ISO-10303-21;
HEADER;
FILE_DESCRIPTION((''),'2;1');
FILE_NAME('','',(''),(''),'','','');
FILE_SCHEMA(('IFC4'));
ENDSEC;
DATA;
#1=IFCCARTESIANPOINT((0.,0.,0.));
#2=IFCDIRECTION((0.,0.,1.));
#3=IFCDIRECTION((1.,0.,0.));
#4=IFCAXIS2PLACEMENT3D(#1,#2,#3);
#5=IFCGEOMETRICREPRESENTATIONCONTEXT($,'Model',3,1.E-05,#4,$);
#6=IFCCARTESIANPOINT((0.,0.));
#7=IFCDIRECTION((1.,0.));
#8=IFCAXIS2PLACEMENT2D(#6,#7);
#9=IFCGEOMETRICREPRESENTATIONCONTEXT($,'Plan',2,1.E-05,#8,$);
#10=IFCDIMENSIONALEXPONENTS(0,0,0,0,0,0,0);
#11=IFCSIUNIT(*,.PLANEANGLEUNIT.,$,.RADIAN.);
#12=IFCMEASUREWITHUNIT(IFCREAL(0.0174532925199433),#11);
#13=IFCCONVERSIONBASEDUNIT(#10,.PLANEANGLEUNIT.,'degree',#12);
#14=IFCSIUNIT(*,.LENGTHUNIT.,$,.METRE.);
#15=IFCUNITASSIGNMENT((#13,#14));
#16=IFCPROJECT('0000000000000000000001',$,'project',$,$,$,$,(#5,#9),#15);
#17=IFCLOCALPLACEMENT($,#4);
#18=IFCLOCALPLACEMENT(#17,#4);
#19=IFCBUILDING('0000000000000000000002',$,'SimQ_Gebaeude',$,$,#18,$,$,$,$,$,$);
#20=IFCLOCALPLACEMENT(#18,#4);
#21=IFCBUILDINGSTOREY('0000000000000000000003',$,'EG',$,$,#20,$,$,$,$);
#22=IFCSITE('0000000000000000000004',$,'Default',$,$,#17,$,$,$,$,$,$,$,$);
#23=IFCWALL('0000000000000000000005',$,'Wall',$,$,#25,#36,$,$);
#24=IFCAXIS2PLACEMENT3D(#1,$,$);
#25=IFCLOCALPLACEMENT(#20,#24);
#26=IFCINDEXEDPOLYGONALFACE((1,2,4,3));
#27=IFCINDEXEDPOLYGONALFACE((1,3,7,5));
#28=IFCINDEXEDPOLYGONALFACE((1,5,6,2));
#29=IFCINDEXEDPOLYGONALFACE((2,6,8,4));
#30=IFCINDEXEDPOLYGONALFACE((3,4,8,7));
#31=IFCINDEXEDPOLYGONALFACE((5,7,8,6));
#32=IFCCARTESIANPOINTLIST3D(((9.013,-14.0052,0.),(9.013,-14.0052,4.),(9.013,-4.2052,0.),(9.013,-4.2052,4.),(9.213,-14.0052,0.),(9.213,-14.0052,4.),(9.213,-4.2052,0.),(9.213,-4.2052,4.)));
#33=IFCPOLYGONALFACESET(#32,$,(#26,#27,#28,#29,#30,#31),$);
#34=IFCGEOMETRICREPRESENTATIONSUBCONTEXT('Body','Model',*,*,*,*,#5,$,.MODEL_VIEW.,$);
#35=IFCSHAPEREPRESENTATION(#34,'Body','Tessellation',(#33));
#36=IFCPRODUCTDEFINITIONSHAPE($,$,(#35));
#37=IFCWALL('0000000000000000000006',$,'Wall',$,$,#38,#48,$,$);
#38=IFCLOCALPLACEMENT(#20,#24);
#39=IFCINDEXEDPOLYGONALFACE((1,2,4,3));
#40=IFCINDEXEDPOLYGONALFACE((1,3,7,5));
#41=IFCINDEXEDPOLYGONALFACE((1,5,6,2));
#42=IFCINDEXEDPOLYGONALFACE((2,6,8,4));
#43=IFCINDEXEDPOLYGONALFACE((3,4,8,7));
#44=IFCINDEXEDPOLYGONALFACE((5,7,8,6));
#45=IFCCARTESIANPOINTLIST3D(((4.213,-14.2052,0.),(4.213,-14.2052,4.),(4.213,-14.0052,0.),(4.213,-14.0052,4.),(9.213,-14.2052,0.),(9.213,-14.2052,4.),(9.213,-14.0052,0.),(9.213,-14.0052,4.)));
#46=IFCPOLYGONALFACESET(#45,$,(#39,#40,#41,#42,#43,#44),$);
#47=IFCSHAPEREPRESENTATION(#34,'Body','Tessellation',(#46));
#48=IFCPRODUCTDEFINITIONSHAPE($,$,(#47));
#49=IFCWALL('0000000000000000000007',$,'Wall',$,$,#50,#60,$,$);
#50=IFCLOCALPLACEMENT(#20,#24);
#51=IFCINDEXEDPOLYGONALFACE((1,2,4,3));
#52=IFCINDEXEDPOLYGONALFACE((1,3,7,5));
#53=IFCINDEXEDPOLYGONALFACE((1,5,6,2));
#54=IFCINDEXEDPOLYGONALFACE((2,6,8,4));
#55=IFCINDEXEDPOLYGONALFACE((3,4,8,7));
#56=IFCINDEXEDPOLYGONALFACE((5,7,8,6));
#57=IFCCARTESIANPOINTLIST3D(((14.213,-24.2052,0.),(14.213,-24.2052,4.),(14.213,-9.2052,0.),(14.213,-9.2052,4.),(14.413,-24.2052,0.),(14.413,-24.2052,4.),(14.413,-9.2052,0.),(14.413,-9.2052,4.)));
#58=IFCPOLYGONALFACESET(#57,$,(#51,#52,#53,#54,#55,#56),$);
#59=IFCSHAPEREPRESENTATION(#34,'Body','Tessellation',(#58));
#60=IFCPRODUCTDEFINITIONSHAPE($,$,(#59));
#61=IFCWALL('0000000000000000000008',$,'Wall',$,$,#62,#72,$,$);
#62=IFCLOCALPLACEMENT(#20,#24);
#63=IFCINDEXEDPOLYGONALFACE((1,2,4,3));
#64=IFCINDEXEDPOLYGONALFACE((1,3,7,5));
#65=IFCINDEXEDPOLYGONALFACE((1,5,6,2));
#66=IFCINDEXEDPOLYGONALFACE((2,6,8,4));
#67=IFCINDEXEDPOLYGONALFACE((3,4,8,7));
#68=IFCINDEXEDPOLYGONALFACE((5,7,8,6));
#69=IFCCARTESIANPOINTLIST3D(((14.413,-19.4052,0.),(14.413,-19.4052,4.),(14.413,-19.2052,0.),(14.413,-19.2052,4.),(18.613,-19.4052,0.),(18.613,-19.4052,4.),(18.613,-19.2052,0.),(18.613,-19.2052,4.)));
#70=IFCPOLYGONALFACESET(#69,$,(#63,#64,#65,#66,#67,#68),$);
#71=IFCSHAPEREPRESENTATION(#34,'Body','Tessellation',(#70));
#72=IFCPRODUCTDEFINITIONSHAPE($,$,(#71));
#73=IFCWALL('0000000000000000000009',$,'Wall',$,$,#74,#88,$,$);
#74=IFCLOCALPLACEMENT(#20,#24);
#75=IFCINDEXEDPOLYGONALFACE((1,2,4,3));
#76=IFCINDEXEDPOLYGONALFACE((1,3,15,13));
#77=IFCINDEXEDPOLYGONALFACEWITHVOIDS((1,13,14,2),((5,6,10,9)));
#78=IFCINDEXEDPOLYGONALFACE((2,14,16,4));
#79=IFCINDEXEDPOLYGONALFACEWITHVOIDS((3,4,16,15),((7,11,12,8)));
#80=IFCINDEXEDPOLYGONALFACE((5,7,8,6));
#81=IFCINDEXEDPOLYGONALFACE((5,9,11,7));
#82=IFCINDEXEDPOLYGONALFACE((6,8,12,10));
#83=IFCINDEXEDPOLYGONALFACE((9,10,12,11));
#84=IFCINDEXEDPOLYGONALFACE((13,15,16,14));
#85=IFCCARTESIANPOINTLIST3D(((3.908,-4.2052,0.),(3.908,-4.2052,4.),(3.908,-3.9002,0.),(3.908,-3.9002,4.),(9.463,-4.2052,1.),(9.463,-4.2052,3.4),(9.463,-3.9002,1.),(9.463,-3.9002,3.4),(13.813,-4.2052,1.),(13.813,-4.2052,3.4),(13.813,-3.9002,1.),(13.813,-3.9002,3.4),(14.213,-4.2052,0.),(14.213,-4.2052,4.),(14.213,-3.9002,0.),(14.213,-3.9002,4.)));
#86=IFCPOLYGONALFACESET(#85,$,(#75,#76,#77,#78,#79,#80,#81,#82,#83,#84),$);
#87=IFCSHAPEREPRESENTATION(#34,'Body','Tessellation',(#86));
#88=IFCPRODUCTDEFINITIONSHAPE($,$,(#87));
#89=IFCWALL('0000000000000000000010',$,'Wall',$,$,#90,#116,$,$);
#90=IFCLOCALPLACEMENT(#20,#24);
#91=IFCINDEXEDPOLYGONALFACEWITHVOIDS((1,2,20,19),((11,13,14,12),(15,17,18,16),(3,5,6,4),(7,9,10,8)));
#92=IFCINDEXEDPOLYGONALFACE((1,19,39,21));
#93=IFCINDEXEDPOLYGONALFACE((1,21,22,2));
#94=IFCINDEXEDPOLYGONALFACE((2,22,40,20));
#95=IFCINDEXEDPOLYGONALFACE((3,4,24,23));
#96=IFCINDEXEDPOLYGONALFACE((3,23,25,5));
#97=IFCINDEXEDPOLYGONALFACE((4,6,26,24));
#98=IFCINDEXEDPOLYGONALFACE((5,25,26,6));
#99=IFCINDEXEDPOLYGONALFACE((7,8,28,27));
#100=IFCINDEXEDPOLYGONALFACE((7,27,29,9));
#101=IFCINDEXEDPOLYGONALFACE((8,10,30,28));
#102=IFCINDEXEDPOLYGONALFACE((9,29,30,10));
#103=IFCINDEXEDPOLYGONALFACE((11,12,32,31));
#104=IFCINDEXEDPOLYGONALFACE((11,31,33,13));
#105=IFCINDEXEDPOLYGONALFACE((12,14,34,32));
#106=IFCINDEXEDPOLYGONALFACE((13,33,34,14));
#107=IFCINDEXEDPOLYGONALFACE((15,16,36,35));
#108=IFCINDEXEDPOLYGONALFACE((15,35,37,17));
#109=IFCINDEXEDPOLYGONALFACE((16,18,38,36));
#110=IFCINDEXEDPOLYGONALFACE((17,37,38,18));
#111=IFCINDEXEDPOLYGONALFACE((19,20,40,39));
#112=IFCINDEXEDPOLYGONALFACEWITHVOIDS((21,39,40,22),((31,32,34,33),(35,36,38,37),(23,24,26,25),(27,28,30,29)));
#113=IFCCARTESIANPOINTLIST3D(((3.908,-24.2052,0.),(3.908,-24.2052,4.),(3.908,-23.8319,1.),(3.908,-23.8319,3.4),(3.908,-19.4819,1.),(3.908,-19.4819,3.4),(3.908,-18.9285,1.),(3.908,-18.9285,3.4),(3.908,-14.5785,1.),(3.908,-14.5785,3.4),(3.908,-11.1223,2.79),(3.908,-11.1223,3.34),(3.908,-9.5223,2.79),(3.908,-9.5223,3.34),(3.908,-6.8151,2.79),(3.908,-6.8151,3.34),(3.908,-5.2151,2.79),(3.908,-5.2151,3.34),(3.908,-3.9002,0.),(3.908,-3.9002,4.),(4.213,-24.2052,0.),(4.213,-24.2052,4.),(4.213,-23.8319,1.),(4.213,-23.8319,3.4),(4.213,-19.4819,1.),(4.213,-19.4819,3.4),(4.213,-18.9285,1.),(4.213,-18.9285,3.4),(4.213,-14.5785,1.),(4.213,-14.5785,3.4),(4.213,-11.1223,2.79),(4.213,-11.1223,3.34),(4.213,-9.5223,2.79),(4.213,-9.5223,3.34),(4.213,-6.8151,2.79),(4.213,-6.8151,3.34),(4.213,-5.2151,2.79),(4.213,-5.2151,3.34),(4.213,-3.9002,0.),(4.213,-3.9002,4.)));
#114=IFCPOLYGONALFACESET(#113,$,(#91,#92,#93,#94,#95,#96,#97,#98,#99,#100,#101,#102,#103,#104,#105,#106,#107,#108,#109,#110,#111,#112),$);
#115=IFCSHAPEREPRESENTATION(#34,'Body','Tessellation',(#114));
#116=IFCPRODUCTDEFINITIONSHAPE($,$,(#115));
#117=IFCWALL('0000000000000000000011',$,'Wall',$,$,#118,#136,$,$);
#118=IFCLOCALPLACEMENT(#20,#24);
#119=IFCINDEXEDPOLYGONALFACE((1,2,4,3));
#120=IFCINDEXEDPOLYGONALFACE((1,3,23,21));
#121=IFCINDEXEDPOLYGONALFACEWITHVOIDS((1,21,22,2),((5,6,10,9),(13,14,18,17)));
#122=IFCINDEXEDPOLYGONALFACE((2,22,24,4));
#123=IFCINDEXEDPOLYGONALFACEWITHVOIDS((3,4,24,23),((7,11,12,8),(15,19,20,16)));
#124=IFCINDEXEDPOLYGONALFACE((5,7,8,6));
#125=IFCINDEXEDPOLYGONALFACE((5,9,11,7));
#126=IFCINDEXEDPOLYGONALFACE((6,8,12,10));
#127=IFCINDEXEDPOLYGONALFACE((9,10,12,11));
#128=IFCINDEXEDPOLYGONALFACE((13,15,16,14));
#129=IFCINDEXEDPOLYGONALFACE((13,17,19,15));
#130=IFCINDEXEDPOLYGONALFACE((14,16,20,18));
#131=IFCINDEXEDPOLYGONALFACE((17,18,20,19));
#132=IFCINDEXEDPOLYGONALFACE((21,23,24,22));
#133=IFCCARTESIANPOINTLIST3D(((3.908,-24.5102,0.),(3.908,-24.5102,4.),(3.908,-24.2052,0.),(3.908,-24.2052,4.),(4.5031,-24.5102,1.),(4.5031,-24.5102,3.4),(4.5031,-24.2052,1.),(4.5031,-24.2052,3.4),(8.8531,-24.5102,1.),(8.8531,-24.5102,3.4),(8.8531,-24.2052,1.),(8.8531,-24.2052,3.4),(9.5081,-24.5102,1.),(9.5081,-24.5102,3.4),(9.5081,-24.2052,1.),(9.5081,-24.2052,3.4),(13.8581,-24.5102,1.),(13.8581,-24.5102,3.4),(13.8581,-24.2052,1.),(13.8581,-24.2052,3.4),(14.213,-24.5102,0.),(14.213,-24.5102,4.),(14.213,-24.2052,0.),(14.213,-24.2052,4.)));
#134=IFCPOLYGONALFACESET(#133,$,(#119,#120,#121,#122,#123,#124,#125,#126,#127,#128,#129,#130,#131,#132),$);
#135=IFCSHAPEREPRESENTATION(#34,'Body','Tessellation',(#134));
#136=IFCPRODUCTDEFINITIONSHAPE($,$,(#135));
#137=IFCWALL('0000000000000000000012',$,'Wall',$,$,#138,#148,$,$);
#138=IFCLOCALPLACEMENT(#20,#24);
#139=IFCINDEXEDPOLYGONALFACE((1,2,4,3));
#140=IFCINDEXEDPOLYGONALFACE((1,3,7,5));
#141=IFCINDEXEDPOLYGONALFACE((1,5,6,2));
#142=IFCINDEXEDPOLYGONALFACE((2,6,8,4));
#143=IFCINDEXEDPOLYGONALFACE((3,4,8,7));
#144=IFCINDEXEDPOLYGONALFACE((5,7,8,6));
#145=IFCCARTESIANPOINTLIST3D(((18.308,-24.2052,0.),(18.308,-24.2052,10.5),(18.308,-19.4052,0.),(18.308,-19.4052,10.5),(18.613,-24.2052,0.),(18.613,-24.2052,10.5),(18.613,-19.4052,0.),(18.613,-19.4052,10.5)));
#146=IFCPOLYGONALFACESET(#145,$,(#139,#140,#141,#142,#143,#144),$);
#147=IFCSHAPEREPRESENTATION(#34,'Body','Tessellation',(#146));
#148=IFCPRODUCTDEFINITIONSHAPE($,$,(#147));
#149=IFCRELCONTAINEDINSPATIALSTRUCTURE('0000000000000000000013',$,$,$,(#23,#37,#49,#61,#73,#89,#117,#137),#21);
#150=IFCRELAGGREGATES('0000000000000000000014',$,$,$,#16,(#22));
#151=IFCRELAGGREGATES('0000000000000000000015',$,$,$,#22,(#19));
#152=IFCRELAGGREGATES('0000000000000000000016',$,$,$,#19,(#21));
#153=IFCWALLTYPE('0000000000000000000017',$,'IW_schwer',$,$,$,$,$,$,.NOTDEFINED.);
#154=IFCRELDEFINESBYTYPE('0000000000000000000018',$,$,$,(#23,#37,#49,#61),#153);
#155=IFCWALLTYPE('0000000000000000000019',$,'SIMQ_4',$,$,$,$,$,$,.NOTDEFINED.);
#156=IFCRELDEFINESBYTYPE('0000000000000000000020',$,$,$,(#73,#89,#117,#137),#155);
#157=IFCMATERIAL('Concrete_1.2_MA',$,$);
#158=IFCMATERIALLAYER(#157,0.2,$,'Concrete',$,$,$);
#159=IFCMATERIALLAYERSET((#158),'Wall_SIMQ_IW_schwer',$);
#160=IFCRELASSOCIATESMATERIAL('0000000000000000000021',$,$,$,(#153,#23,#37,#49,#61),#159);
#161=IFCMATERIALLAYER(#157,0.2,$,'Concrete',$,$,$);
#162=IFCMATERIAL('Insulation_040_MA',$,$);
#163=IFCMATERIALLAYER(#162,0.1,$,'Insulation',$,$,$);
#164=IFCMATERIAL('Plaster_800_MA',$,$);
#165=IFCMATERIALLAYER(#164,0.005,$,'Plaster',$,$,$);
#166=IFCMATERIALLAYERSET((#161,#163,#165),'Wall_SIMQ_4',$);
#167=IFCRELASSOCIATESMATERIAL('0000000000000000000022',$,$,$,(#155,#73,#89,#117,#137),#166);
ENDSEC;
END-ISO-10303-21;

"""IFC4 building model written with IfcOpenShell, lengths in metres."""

from ifc_helpers import new_model, entity, si_unit, converted_unit, frame, origin_with_axes, origin_2d_with_axis, place, context, subcontext, project, spatial, line, indexed_curve, outline, extrude, source, transform, mapped, material, layer, layer_set, layer_usage, type_object, element, save


model = new_model("IFC4")

# Units and contexts
model_context = context("Model", 3, precision=1e-05, world=origin_with_axes())
plan_context = context("Plan", 2, precision=1e-05, world=origin_2d_with_axis())
body_context_1 = subcontext(model_context, "Body", "Model", "MODEL_VIEW")
ifc_project = project(units=[converted_unit("PLANEANGLEUNIT", "degree", entity("IfcReal", 0.0174532925199433), si_unit("PLANEANGLEUNIT", "RADIAN"), dimensions=[0, 0, 0, 0, 0, 0, 0]), si_unit("LENGTHUNIT", "METRE")], contexts=[model_context, plan_context])

# Site, building, storey
site_placement = place(None, origin_with_axes())
site = spatial("IfcSite", under=ifc_project, at=site_placement, Name="Default")
building_placement = place(site_placement, origin_with_axes())
building = spatial("IfcBuilding", under=site, at=building_placement, Name="SimQ_Gebaeude")
storey_placement = place(building_placement, origin_with_axes())
storey = spatial("IfcBuildingStorey", under=building, at=storey_placement, Name="EG")

# Shared definitions
ifc_material_1 = material(Name="Insulation_040_MA")
ifc_material_2 = material(Name="Concrete_1.2_MA")

# Walls
ifc_layer_1 = layer(ifc_material_2, 0.2, Name="Concrete")
ifc_layer_set_1 = layer_set([ifc_layer_1], Name="Wall_SIMQ_IW_schwer")
ifc_layer_usage_1 = layer_usage(ifc_layer_set_1, "AXIS2", "POSITIVE", 0.0)
wall_type_1 = type_object("IfcWallType", Name="IW_schwer", PredefinedType="NOTDEFINED", material=ifc_layer_set_1)
wall_1_placement = place(storey_placement, frame((9.213, -14.0052, 0.0), z_axis=(0.0, 0.0, 1.0), x_axis=(0.000001, 1.0, 0.0)))
element("IfcWall", 1, at=wall_1_placement, inside=storey, type_object=wall_type_1, material=ifc_layer_usage_1, Name="Wall", context=body_context_1, shape_type="SweptSolid", body=[
    extrude(outline(indexed_curve([(0.0, 0.0), (0.0, 0.2), (9.8, 0.2), (9.8, 0.0), (0.0, 0.0)], self_intersect=False)), origin_with_axes(), (0.0, 0.0, 1.0), 4.0),
])
ifc_layer_usage_2 = layer_usage(ifc_layer_set_1, "AXIS2", "POSITIVE", 0.0)
wall_2_placement = place(storey_placement, frame((9.213, -14.0052, 0.0), z_axis=(0.0, 0.0, 1.0), x_axis=(-1.0, 0.000001, 0.0)))
element("IfcWall", 2, at=wall_2_placement, inside=storey, type_object=wall_type_1, material=ifc_layer_usage_2, Name="Wall", context=body_context_1, shape_type="SweptSolid", body=[
    extrude(outline(indexed_curve([(0.0, 0.0), (0.0, 0.2), (5.0, 0.2), (5.0, 0.0), (0.0, 0.0)], self_intersect=False)), origin_with_axes(), (0.0, 0.0, 1.0), 4.0),
])
ifc_layer_usage_3 = layer_usage(ifc_layer_set_1, "AXIS2", "POSITIVE", 0.0)
wall_3_placement = place(storey_placement, frame((14.213, -9.2052, 0.0), z_axis=(0.0, 0.0, 1.0), x_axis=(-0.000001, -1.0, 0.0)))
element("IfcWall", 3, at=wall_3_placement, inside=storey, type_object=wall_type_1, material=ifc_layer_usage_3, Name="Wall", context=body_context_1, shape_type="SweptSolid", body=[
    extrude(outline(indexed_curve([(0.0, 0.0), (0.0, 0.2), (15.0, 0.2), (15.0, 0.0), (0.0, 0.0)], self_intersect=False)), origin_with_axes(), (0.0, 0.0, 1.0), 4.0),
])
ifc_layer_usage_4 = layer_usage(ifc_layer_set_1, "AXIS2", "POSITIVE", 0.0)
wall_4_placement = place(storey_placement, frame((18.613, -19.2052, 0.0), z_axis=(0.0, 0.0, 1.0), x_axis=(-1.0, 0.0, 0.0)))
element("IfcWall", 4, at=wall_4_placement, inside=storey, type_object=wall_type_1, material=ifc_layer_usage_4, Name="Wall", context=body_context_1, shape_type="SweptSolid", body=[
    extrude(outline(indexed_curve([(0.0, 0.0), (0.0, 0.2), (4.2, 0.2), (4.2, 0.0), (0.0, 0.0)], self_intersect=False)), origin_with_axes(), (0.0, 0.0, 1.0), 4.0),
])

# Wall, opening
ifc_layer_2 = layer(ifc_material_2, 0.2, Name="Concrete")
ifc_layer_3 = layer(ifc_material_1, 0.1, Name="Insulation")
ifc_material_3 = material(Name="Plaster_800_MA")
ifc_layer_4 = layer(ifc_material_3, 0.005, Name="Plaster")
ifc_layer_set_2 = layer_set([ifc_layer_2, ifc_layer_3, ifc_layer_4], Name="Wall_SIMQ_4")
ifc_layer_usage_5 = layer_usage(ifc_layer_set_2, "AXIS2", "POSITIVE", 0.0)
wall_type_2 = type_object("IfcWallType", Name="SIMQ_4", PredefinedType="NOTDEFINED", material=ifc_layer_set_2)
wall_5_placement = place(storey_placement, frame((14.213, -3.9002, 0.0), z_axis=(0.0, 0.0, 1.0), x_axis=(-1.0, 0.0, 0.0)))
wall_5 = element("IfcWall", 5, at=wall_5_placement, inside=storey, type_object=wall_type_2, material=ifc_layer_usage_5, Name="Wall", context=body_context_1, shape_type="SweptSolid", body=[
    extrude(outline(indexed_curve([(0.0, 0.0), (0.0, 0.305), (10.305, 0.305), (10.305, 0.0), (0.0, 0.0)], self_intersect=False)), origin_with_axes(), (0.0, 0.0, 1.0), 4.0),
])
shared_shape_1 = source(origin_with_axes(), body_context_1, "Body", "SweptSolid", [
    extrude(outline(indexed_curve([(0.0, 0.0), (4.35, 0.0), (4.35, 2.4), (0.0, 2.4)], segments=[line(1, 2, 3, 4, 1)])), frame((0.0, -0.6, 0.0), z_axis=(0.0, -1.0, 0.0), x_axis=(1.0, 0.0, 0.0)), (0.0, 0.0, -1.0), 1.2),
])
opening_1_placement = place(wall_5_placement, frame((0.4, 0.0, 1.0), z_axis=(0.0, 0.0, 1.0), x_axis=(1.0, 0.0, 0.0)))
element("IfcOpeningElement", 6, at=opening_1_placement, cuts=wall_5, PredefinedType="OPENING", context=body_context_1, shape_type="MappedRepresentation", body=[
    mapped(shared_shape_1, transform((0.0, 0.0, 0.0), x_axis=(1.0, 0.0, 0.0), y_axis=(0.0, 1.0, 0.0), z_axis=(0.0, 0.0, 1.0), scale=1.0)),
])

# Walls, openings
ifc_layer_usage_6 = layer_usage(ifc_layer_set_2, "AXIS2", "POSITIVE", 0.0)
wall_6_placement = place(storey_placement, frame((3.908, -3.9002, 0.0), z_axis=(0.0, 0.0, 1.0), x_axis=(-0.000001, -1.0, 0.0)))
wall_6 = element("IfcWall", 7, at=wall_6_placement, inside=storey, type_object=wall_type_2, material=ifc_layer_usage_6, Name="Wall", context=body_context_1, shape_type="SweptSolid", body=[
    extrude(outline(indexed_curve([(0.0, 0.0), (0.0, 0.305), (20.305, 0.305), (20.305, 0.0), (0.0, 0.0)], self_intersect=False)), origin_with_axes(), (0.0, 0.0, 1.0), 4.0),
])
opening_2_placement = place(wall_6_placement, frame((15.5817, 0.0, 1.0), z_axis=(0.0, 0.0, 1.0), x_axis=(1.0, 0.0, 0.0)))
element("IfcOpeningElement", 8, at=opening_2_placement, cuts=wall_6, PredefinedType="OPENING", context=body_context_1, shape_type="MappedRepresentation", body=[
    mapped(shared_shape_1, transform((0.0, 0.0, 0.0), x_axis=(1.0, 0.0, 0.0), y_axis=(0.0, 1.0, 0.0), z_axis=(0.0, 0.0, 1.0), scale=1.0)),
])
opening_3_placement = place(wall_6_placement, frame((10.6783, 0.0, 1.0), z_axis=(0.0, 0.0, 1.0), x_axis=(1.0, 0.0, 0.0)))
element("IfcOpeningElement", 9, at=opening_3_placement, cuts=wall_6, PredefinedType="OPENING", context=body_context_1, shape_type="MappedRepresentation", body=[
    mapped(shared_shape_1, transform((0.0, 0.0, 0.0), x_axis=(1.0, 0.0, 0.0), y_axis=(0.0, 1.0, 0.0), z_axis=(0.0, 0.0, 1.0), scale=1.0)),
])
shared_shape_2 = source(origin_with_axes(), body_context_1, "Body", "SweptSolid", [
    extrude(outline(indexed_curve([(0.0, 0.0), (1.6, 0.0), (1.6, 0.55), (0.0, 0.55)], segments=[line(1, 2, 3, 4, 1)])), frame((0.0, -0.6, 0.0), z_axis=(0.0, -1.0, 0.0), x_axis=(1.0, 0.0, 0.0)), (0.0, 0.0, -1.0), 1.2),
])
opening_4_placement = place(wall_6_placement, frame((5.6221, 0.0, 2.79), z_axis=(0.0, 0.0, 1.0), x_axis=(1.0, 0.0, 0.0)))
element("IfcOpeningElement", 10, at=opening_4_placement, cuts=wall_6, PredefinedType="OPENING", context=body_context_1, shape_type="MappedRepresentation", body=[
    mapped(shared_shape_2, transform((0.0, 0.0, 0.0), x_axis=(1.0, 0.0, 0.0), y_axis=(0.0, 1.0, 0.0), z_axis=(0.0, 0.0, 1.0), scale=1.0)),
])
opening_5_placement = place(wall_6_placement, frame((1.3149, 0.0, 2.79), z_axis=(0.0, 0.0, 1.0), x_axis=(1.0, 0.0, 0.0)))
element("IfcOpeningElement", 11, at=opening_5_placement, cuts=wall_6, PredefinedType="OPENING", context=body_context_1, shape_type="MappedRepresentation", body=[
    mapped(shared_shape_2, transform((0.0, 0.0, 0.0), x_axis=(1.0, 0.0, 0.0), y_axis=(0.0, 1.0, 0.0), z_axis=(0.0, 0.0, 1.0), scale=1.0)),
])
ifc_layer_usage_7 = layer_usage(ifc_layer_set_2, "AXIS2", "POSITIVE", 0.0)
wall_7_placement = place(storey_placement, frame((3.908, -24.5102, 0.0), z_axis=(0.0, 0.0, 1.0), x_axis=(1.0, -0.000001, 0.0)))
wall_7 = element("IfcWall", 12, at=wall_7_placement, inside=storey, type_object=wall_type_2, material=ifc_layer_usage_7, Name="Wall", context=body_context_1, shape_type="SweptSolid", body=[
    extrude(outline(indexed_curve([(0.0, 0.0), (0.0, 0.305), (10.305, 0.305), (10.305, 0.0), (0.0, 0.0)], self_intersect=False)), origin_with_axes(), (0.0, 0.0, 1.0), 4.0),
])
opening_6_placement = place(wall_7_placement, frame((0.5951, 0.0, 1.0), z_axis=(0.0, 0.0, 1.0), x_axis=(1.0, 0.0, 0.0)))
element("IfcOpeningElement", 13, at=opening_6_placement, cuts=wall_7, PredefinedType="OPENING", context=body_context_1, shape_type="MappedRepresentation", body=[
    mapped(shared_shape_1, transform((0.0, 0.0, 0.0), x_axis=(1.0, 0.0, 0.0), y_axis=(0.0, 1.0, 0.0), z_axis=(0.0, 0.0, 1.0), scale=1.0)),
])
opening_7_placement = place(wall_7_placement, frame((5.6001, 0.0, 1.0), z_axis=(0.0, 0.0, 1.0), x_axis=(1.0, 0.0, 0.0)))
element("IfcOpeningElement", 14, at=opening_7_placement, cuts=wall_7, PredefinedType="OPENING", context=body_context_1, shape_type="MappedRepresentation", body=[
    mapped(shared_shape_1, transform((0.0, 0.0, 0.0), x_axis=(1.0, 0.0, 0.0), y_axis=(0.0, 1.0, 0.0), z_axis=(0.0, 0.0, 1.0), scale=1.0)),
])

# Wall
ifc_layer_usage_8 = layer_usage(ifc_layer_set_2, "AXIS2", "POSITIVE", 0.0)
wall_8_placement = place(storey_placement, frame((18.613, -24.2052, 0.0), z_axis=(0.0, 0.0, 1.0), x_axis=(0.0, 1.0, 0.0)))
element("IfcWall", 15, at=wall_8_placement, inside=storey, type_object=wall_type_2, material=ifc_layer_usage_8, Name="Wall", context=body_context_1, shape_type="SweptSolid", body=[
    extrude(outline(indexed_curve([(0.0, 0.0), (0.0, 0.305), (4.8, 0.305), (4.8, 0.0), (0.0, 0.0)], self_intersect=False)), origin_with_axes(), (0.0, 0.0, 1.0), 10.5),
])

save(model, "model.ifc")
